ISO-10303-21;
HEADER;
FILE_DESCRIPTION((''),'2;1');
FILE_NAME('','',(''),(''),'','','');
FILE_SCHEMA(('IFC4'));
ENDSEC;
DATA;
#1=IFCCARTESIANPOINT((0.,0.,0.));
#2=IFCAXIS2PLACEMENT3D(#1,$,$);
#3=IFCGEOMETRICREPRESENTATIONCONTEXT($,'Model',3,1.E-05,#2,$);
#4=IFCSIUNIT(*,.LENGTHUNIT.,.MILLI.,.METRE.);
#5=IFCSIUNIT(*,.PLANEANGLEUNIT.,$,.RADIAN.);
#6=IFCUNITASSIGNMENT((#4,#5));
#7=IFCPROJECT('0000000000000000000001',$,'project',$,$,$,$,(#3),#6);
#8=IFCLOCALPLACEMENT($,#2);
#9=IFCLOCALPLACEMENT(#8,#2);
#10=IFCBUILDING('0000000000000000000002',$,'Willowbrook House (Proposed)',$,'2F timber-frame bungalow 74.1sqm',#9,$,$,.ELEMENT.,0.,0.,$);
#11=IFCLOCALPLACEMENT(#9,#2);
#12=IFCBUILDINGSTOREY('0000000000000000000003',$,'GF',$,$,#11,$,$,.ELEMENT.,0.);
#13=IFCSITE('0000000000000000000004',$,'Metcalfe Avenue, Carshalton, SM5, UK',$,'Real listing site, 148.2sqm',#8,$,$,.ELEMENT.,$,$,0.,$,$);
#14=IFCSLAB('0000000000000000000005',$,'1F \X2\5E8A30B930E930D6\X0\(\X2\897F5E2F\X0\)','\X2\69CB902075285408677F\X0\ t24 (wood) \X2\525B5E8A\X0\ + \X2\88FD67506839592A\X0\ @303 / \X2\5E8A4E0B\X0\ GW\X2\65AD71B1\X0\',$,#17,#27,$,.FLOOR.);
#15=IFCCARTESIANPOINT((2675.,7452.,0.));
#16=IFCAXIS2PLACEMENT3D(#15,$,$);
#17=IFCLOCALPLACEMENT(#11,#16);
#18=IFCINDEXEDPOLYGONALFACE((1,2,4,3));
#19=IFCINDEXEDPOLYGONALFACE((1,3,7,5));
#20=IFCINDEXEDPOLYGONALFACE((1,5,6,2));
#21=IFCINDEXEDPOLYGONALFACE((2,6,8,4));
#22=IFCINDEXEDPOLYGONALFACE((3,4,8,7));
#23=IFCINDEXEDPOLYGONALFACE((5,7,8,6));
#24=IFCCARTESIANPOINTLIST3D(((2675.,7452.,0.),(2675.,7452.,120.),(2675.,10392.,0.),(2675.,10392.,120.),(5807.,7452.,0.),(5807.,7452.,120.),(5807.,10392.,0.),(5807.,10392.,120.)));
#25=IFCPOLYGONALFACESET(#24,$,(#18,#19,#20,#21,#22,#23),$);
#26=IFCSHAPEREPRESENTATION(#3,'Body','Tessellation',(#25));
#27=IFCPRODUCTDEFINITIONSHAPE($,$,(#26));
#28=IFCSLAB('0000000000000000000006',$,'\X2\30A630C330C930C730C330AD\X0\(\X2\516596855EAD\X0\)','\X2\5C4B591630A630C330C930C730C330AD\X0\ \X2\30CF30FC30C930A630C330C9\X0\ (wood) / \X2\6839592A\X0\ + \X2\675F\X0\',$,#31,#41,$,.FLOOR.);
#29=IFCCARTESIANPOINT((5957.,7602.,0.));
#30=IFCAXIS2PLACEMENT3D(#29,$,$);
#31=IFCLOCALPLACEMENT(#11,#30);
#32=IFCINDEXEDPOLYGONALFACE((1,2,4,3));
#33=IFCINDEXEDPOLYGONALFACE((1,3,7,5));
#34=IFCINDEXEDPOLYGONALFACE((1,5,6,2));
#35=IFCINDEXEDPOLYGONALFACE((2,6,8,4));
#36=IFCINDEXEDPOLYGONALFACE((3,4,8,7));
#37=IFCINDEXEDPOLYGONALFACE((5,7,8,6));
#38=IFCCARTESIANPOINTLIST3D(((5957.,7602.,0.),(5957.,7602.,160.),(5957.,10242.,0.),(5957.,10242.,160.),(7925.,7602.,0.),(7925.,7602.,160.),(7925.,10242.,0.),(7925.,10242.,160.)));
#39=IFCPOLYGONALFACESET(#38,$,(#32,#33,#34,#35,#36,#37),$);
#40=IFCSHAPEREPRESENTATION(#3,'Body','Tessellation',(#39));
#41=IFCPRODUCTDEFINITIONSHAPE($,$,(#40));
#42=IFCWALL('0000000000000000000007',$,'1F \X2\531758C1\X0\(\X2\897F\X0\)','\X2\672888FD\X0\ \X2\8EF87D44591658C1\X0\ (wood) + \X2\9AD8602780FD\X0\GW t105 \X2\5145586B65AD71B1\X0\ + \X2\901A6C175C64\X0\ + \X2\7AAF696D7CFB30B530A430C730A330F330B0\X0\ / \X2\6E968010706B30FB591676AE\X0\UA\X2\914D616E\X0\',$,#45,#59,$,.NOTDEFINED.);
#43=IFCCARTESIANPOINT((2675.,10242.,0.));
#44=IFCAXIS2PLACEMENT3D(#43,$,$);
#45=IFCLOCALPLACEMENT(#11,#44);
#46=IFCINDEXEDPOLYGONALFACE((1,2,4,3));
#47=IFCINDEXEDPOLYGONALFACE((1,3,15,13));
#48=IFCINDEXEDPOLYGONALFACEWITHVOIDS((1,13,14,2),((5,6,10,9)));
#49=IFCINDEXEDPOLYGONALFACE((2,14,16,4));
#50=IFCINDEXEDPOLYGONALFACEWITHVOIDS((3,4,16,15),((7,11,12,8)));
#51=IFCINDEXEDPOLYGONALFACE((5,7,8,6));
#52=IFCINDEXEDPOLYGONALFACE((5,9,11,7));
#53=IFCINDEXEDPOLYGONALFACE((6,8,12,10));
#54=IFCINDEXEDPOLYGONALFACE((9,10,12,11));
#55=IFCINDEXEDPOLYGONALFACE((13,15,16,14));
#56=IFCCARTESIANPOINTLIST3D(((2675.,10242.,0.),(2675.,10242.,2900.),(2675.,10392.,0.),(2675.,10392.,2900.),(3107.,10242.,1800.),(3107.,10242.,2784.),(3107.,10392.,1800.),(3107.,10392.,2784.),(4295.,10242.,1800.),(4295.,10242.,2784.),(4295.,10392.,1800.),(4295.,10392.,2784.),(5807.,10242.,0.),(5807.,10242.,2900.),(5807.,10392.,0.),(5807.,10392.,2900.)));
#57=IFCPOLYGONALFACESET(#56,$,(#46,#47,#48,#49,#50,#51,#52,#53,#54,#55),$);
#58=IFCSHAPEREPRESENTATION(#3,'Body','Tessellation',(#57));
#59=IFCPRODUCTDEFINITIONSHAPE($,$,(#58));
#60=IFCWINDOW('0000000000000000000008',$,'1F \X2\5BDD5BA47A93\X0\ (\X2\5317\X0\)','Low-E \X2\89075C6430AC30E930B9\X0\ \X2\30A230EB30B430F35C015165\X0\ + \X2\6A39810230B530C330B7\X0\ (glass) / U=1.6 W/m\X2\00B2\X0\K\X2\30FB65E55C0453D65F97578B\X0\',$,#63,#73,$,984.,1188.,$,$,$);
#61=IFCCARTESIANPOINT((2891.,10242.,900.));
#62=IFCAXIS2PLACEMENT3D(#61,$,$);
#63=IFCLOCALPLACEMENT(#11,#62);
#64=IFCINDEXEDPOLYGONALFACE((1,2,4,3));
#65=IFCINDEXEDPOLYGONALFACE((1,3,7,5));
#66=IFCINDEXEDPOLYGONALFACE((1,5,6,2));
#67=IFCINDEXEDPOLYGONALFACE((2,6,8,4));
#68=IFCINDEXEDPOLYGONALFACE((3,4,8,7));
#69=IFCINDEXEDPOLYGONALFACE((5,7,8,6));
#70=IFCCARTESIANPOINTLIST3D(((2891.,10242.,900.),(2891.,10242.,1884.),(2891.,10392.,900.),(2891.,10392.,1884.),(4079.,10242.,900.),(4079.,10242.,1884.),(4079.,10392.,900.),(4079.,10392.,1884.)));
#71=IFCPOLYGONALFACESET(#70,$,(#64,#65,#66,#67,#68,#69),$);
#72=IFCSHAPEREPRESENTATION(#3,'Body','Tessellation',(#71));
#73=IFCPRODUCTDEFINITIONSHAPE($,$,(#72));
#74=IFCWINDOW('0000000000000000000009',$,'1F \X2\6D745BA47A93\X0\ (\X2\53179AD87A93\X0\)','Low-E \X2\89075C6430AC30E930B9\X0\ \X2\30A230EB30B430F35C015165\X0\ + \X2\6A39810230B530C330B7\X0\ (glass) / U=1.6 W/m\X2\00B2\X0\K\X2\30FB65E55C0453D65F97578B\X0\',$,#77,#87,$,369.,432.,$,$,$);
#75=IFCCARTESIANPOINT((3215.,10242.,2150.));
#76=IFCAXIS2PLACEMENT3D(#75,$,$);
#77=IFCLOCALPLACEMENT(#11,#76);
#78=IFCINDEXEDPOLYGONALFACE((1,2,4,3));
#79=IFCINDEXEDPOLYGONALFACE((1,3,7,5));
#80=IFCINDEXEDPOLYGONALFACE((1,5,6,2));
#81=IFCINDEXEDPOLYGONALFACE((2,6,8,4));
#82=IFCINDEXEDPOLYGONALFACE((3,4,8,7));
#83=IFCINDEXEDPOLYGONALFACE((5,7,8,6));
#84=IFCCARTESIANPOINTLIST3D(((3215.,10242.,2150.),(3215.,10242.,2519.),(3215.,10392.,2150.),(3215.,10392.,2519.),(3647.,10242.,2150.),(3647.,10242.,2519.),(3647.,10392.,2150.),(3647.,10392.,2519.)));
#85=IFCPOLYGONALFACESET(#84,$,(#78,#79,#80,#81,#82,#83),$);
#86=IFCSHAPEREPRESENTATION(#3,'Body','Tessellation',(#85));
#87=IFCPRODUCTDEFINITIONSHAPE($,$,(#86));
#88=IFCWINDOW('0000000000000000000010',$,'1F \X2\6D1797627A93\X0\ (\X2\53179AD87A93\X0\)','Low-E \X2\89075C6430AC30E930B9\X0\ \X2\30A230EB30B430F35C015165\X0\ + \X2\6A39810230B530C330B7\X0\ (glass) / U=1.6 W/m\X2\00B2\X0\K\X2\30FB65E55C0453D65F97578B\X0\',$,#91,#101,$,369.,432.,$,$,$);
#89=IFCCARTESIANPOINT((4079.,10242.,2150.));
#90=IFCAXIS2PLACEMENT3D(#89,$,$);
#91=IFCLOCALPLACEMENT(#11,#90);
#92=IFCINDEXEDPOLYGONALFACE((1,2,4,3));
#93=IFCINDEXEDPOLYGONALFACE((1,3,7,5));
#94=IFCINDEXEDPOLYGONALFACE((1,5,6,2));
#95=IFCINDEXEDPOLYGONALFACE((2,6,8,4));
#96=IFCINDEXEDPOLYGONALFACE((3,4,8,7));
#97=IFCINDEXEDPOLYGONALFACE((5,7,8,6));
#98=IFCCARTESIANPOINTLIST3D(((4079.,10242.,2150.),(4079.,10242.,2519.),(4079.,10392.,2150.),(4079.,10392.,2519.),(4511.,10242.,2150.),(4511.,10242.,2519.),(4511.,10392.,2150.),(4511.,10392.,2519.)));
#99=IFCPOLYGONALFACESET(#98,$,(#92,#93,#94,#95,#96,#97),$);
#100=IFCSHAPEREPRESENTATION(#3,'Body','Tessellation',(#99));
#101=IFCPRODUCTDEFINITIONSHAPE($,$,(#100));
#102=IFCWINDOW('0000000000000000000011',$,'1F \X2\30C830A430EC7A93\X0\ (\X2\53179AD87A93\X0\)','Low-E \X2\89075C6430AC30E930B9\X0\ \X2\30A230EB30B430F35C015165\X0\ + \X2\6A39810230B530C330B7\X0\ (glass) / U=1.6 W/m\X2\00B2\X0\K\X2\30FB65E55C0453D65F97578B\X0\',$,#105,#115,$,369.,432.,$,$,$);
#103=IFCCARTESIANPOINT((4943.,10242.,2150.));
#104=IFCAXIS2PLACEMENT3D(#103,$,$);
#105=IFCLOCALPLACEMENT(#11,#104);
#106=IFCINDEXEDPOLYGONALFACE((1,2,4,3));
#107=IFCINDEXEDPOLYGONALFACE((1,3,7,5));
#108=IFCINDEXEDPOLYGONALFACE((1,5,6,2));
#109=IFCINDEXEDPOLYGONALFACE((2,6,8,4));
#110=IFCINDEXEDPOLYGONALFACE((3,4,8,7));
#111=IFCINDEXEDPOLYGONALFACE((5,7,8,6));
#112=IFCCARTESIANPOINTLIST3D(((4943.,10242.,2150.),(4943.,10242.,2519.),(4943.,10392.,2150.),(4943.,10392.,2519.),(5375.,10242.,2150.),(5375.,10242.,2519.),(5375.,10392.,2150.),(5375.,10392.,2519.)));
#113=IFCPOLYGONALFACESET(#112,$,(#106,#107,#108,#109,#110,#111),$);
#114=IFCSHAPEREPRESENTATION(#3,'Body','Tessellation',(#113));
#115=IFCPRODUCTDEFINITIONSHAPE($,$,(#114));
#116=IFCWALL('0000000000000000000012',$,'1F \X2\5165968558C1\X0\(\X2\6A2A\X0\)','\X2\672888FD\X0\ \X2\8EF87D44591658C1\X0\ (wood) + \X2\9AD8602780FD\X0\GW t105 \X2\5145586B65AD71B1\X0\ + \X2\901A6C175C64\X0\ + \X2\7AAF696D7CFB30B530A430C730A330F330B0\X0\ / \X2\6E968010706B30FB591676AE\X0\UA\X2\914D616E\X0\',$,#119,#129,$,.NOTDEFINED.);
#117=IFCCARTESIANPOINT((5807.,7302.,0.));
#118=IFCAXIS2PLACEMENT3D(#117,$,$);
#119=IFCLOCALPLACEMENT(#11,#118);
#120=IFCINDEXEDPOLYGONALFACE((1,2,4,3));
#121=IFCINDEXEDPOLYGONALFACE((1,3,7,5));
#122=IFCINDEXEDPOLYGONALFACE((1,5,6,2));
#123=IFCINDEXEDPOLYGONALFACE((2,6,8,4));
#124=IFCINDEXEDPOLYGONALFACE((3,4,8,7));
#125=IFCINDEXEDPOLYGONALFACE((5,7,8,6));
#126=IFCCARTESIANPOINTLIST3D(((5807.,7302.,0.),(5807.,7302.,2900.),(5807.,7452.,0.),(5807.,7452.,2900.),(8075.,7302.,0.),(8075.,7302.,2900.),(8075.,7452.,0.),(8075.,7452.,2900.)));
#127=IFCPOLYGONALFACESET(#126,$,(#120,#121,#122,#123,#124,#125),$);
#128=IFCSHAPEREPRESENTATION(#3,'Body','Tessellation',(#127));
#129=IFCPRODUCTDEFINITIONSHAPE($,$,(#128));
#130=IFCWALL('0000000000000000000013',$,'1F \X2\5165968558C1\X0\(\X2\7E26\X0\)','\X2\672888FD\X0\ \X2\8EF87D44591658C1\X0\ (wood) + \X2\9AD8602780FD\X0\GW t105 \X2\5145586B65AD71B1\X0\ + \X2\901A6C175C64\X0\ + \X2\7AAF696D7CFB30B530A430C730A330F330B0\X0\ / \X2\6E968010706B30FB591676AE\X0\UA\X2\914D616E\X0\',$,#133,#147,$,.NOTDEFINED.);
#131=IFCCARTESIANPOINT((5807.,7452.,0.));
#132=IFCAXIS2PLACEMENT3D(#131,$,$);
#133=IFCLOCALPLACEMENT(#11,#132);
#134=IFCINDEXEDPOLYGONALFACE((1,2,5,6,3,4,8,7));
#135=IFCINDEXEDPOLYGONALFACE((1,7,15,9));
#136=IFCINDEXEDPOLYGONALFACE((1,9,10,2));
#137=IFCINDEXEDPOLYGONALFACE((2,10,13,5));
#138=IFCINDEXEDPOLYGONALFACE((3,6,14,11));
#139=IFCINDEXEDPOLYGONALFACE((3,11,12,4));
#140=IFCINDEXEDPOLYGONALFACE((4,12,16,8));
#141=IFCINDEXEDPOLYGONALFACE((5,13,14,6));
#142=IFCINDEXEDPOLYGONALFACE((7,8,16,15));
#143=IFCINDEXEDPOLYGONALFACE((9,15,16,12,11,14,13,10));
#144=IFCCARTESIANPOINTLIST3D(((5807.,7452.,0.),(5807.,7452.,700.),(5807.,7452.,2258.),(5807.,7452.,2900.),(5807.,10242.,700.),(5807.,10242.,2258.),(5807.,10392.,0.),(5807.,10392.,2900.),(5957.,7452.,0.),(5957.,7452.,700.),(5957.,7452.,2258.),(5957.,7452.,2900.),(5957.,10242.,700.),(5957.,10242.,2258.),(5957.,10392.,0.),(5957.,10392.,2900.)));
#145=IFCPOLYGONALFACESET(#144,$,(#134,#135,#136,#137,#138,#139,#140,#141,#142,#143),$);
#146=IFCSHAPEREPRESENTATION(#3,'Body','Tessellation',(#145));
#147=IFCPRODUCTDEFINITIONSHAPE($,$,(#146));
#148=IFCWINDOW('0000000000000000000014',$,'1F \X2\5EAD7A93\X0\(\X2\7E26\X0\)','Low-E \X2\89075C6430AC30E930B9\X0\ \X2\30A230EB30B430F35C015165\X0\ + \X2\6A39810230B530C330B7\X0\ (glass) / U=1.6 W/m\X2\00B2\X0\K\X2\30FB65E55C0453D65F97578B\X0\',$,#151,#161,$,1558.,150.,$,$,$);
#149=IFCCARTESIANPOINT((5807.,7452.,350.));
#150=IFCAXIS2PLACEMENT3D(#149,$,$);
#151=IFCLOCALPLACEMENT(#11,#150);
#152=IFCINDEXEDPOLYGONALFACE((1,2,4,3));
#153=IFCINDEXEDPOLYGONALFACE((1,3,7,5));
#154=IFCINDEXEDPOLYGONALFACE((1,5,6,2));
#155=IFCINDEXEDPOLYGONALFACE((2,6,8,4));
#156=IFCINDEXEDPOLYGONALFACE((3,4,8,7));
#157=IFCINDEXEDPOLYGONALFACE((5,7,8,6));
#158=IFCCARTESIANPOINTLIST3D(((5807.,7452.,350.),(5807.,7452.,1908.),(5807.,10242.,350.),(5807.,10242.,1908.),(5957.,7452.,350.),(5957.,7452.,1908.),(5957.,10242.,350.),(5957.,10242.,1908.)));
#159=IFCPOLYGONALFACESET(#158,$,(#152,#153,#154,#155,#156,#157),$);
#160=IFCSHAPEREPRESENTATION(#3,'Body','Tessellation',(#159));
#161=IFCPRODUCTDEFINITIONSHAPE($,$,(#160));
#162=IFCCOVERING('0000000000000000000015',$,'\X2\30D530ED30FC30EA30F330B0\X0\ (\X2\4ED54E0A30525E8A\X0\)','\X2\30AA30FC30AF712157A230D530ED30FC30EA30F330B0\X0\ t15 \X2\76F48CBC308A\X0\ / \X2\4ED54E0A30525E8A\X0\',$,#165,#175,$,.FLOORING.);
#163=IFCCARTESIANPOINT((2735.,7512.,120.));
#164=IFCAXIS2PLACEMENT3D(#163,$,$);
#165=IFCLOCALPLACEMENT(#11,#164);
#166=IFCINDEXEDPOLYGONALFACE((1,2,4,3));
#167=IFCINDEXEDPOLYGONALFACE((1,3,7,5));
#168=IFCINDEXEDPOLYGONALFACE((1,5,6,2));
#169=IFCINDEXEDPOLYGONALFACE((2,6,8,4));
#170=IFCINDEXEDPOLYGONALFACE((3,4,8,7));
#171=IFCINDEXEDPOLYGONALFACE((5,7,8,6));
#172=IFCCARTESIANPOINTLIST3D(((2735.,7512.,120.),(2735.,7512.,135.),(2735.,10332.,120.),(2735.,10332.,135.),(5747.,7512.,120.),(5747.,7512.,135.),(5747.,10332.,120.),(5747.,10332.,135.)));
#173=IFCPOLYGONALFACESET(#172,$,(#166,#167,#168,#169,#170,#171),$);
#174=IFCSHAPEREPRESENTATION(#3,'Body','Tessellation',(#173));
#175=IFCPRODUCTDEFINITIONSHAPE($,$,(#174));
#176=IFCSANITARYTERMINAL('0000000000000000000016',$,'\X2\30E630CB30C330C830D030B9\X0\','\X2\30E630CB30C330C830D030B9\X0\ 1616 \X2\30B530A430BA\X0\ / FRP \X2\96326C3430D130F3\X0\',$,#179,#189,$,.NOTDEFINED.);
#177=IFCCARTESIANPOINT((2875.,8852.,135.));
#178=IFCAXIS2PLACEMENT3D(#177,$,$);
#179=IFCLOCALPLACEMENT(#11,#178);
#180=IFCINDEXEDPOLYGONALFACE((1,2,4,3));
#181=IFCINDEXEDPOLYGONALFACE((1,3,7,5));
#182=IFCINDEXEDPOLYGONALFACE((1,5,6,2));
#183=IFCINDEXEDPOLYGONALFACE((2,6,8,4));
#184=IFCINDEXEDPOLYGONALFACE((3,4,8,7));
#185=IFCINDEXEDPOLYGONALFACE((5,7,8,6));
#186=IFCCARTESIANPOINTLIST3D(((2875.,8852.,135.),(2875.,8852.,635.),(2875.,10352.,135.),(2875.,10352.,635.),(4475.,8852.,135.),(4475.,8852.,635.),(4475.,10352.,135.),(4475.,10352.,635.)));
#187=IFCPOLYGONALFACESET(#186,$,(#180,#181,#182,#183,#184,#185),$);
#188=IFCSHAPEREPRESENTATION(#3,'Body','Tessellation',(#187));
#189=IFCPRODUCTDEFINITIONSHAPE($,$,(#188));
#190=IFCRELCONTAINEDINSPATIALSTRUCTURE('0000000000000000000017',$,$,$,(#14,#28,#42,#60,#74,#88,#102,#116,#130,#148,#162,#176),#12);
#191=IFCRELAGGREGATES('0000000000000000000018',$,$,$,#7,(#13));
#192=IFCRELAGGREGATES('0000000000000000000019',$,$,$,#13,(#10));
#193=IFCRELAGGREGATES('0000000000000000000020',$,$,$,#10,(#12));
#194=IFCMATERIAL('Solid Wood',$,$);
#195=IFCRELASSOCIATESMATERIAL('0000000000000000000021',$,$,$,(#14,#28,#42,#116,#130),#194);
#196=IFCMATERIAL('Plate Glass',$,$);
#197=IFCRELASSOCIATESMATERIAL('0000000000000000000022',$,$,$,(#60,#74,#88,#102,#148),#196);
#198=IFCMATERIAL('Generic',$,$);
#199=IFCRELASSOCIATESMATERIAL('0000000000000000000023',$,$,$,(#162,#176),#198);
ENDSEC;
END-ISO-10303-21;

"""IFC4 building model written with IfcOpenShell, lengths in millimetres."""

from ifc_helpers import new_model, si_unit, frame, frame_2d, origin, place, context, project, spatial, rectangle, extrude, material, element, fill, save


model = new_model("IFC4")

# Units and contexts
model_context = context("Model", 3, precision=1e-05, world=origin())
ifc_project = project(units=[si_unit("LENGTHUNIT", "METRE", prefix="MILLI"), si_unit("PLANEANGLEUNIT", "RADIAN")], contexts=[model_context])

# Site, building, storey
site_placement = place(None, origin())
site = spatial("IfcSite", under=ifc_project, at=site_placement, Name="Metcalfe Avenue, Carshalton, SM5, UK", ObjectType="Real listing site, 148.2sqm", CompositionType="ELEMENT", RefElevation=0.0)
building_placement = place(site_placement, origin())
building = spatial("IfcBuilding", under=site, at=building_placement, Name="Willowbrook House (Proposed)", ObjectType="2F timber-frame bungalow 74.1sqm", CompositionType="ELEMENT", ElevationOfRefHeight=0.0, ElevationOfTerrain=0.0)
storey_placement = place(building_placement, origin())
storey = spatial("IfcBuildingStorey", under=building, at=storey_placement, Name="GF", CompositionType="ELEMENT", Elevation=0.0)

# Slabs
ifc_material_1 = material(Name="Solid Wood")
slab_1_placement = place(storey_placement, frame((2675.0, 7452.0, 0.0)))
element("IfcSlab", 1, at=slab_1_placement, inside=storey, material=ifc_material_1, Name="1F 床スラブ(西帯)", Description="構造用合板 t24 (wood) 剛床 + 製材根太 @303 / 床下 GW断熱", PredefinedType="FLOOR", context=model_context, shape_type="SweptSolid", body=[
    extrude(rectangle(XDim=3132.0, YDim=2940.0, at=frame_2d((1566.0, 1470.0))), frame((2675.0, 7452.0, 0.0)), (0.0, 0.0, 1.0), 120.0),
])
slab_2_placement = place(storey_placement, frame((5957.0, 7602.0, 0.0)))
element("IfcSlab", 2, at=slab_2_placement, inside=storey, material=ifc_material_1, Name="ウッドデッキ(入隅庭)", Description="屋外ウッドデッキ ハードウッド (wood) / 根太 + 束", PredefinedType="FLOOR", context=model_context, shape_type="SweptSolid", body=[
    extrude(rectangle(XDim=1968.0, YDim=2640.0, at=frame_2d((984.0, 1320.0))), frame((5957.0, 7602.0, 0.0)), (0.0, 0.0, 1.0), 160.0),
])

# Wall, openings, windows
wall_1_placement = place(storey_placement, frame((2675.0, 10242.0, 0.0)))
wall_1 = element("IfcWall", 3, at=wall_1_placement, inside=storey, material=ifc_material_1, Name="1F 北壁(西)", Description="木製 軸組外壁 (wood) + 高性能GW t105 充填断熱 + 通気層 + 窯業系サイディング / 準耐火・外皮UA配慮", PredefinedType="NOTDEFINED", context=model_context, shape_type="SweptSolid", body=[
    extrude(rectangle(XDim=3132.0, YDim=150.0, at=frame_2d((1566.0, 75.0))), frame((2675.0, 10242.0, 0.0)), (0.0, 0.0, 1.0), 2900.0),
])
opening_1_placement = place(storey_placement, frame((2891.0, 10242.0, 900.0)))
opening_1 = element("IfcOpeningElement", 4, at=opening_1_placement, cuts=wall_1, PredefinedType="NOTDEFINED", context=model_context, shape_type="SweptSolid", body=[
    extrude(rectangle(XDim=1188.0, YDim=150.0, at=frame_2d((594.0, 75.0))), frame((2891.0, 10242.0, 900.0)), (0.0, 0.0, 1.0), 984.0),
])
opening_2_placement = place(storey_placement, frame((3215.0, 10242.0, 2150.0)))
opening_2 = element("IfcOpeningElement", 5, at=opening_2_placement, cuts=wall_1, PredefinedType="NOTDEFINED", context=model_context, shape_type="SweptSolid", body=[
    extrude(rectangle(XDim=432.0, YDim=150.0, at=frame_2d((216.0, 75.0))), frame((3215.0, 10242.0, 2150.0)), (0.0, 0.0, 1.0), 369.0),
])
opening_3_placement = place(storey_placement, frame((4079.0, 10242.0, 2150.0)))
opening_3 = element("IfcOpeningElement", 6, at=opening_3_placement, cuts=wall_1, PredefinedType="NOTDEFINED", context=model_context, shape_type="SweptSolid", body=[
    extrude(rectangle(XDim=432.0, YDim=150.0, at=frame_2d((216.0, 75.0))), frame((4079.0, 10242.0, 2150.0)), (0.0, 0.0, 1.0), 369.0),
])
opening_4_placement = place(storey_placement, frame((4943.0, 10242.0, 2150.0)))
opening_4 = element("IfcOpeningElement", 7, at=opening_4_placement, cuts=wall_1, PredefinedType="NOTDEFINED", context=model_context, shape_type="SweptSolid", body=[
    extrude(rectangle(XDim=432.0, YDim=150.0, at=frame_2d((216.0, 75.0))), frame((4943.0, 10242.0, 2150.0)), (0.0, 0.0, 1.0), 369.0),
])
ifc_material_2 = material(Name="Plate Glass")
window_1_placement = place(storey_placement, frame((2891.0, 10242.0, 900.0)))
window_1 = element("IfcWindow", 8, at=window_1_placement, inside=storey, material=ifc_material_2, Name="1F 寝室窓 (北)", Description="Low-E 複層ガラス アルゴン封入 + 樹脂サッシ (glass) / U=1.6 W/m²K・日射取得型", OverallHeight=984.0, OverallWidth=1188.0, context=model_context, shape_type="SweptSolid", body=[
    extrude(rectangle(XDim=1188.0, YDim=150.0, at=frame_2d((594.0, 75.0))), frame((2891.0, 10242.0, 900.0)), (0.0, 0.0, 1.0), 984.0),
])
fill(opening_1, window_1)
window_2_placement = place(storey_placement, frame((3215.0, 10242.0, 2150.0)))
window_2 = element("IfcWindow", 9, at=window_2_placement, inside=storey, material=ifc_material_2, Name="1F 浴室窓 (北高窓)", Description="Low-E 複層ガラス アルゴン封入 + 樹脂サッシ (glass) / U=1.6 W/m²K・日射取得型", OverallHeight=369.0, OverallWidth=432.0, context=model_context, shape_type="SweptSolid", body=[
    extrude(rectangle(XDim=432.0, YDim=150.0, at=frame_2d((216.0, 75.0))), frame((3215.0, 10242.0, 2150.0)), (0.0, 0.0, 1.0), 369.0),
])
fill(opening_2, window_2)
window_3_placement = place(storey_placement, frame((4079.0, 10242.0, 2150.0)))
window_3 = element("IfcWindow", 10, at=window_3_placement, inside=storey, material=ifc_material_2, Name="1F 洗面窓 (北高窓)", Description="Low-E 複層ガラス アルゴン封入 + 樹脂サッシ (glass) / U=1.6 W/m²K・日射取得型", OverallHeight=369.0, OverallWidth=432.0, context=model_context, shape_type="SweptSolid", body=[
    extrude(rectangle(XDim=432.0, YDim=150.0, at=frame_2d((216.0, 75.0))), frame((4079.0, 10242.0, 2150.0)), (0.0, 0.0, 1.0), 369.0),
])
fill(opening_3, window_3)
window_4_placement = place(storey_placement, frame((4943.0, 10242.0, 2150.0)))
window_4 = element("IfcWindow", 11, at=window_4_placement, inside=storey, material=ifc_material_2, Name="1F トイレ窓 (北高窓)", Description="Low-E 複層ガラス アルゴン封入 + 樹脂サッシ (glass) / U=1.6 W/m²K・日射取得型", OverallHeight=369.0, OverallWidth=432.0, context=model_context, shape_type="SweptSolid", body=[
    extrude(rectangle(XDim=432.0, YDim=150.0, at=frame_2d((216.0, 75.0))), frame((4943.0, 10242.0, 2150.0)), (0.0, 0.0, 1.0), 369.0),
])
fill(opening_4, window_4)

# Wall
wall_2_placement = place(storey_placement, frame((5807.0, 7302.0, 0.0)))
element("IfcWall", 12, at=wall_2_placement, inside=storey, material=ifc_material_1, Name="1F 入隅壁(横)", Description="木製 軸組外壁 (wood) + 高性能GW t105 充填断熱 + 通気層 + 窯業系サイディング / 準耐火・外皮UA配慮", PredefinedType="NOTDEFINED", context=model_context, shape_type="SweptSolid", body=[
    extrude(rectangle(XDim=2268.0, YDim=150.0, at=frame_2d((1134.0, 75.0))), frame((5807.0, 7302.0, 0.0)), (0.0, 0.0, 1.0), 2900.0),
])

# Wall, opening, window
wall_3_placement = place(storey_placement, frame((5807.0, 7452.0, 0.0)))
wall_3 = element("IfcWall", 13, at=wall_3_placement, inside=storey, material=ifc_material_1, Name="1F 入隅壁(縦)", Description="木製 軸組外壁 (wood) + 高性能GW t105 充填断熱 + 通気層 + 窯業系サイディング / 準耐火・外皮UA配慮", PredefinedType="NOTDEFINED", context=model_context, shape_type="SweptSolid", body=[
    extrude(rectangle(XDim=150.0, YDim=2940.0, at=frame_2d((75.0, 1470.0))), frame((5807.0, 7452.0, 0.0)), (0.0, 0.0, 1.0), 2900.0),
])
opening_5_placement = place(storey_placement, frame((5807.0, 7452.0, 350.0)))
opening_5 = element("IfcOpeningElement", 14, at=opening_5_placement, cuts=wall_3, PredefinedType="NOTDEFINED", context=model_context, shape_type="SweptSolid", body=[
    extrude(rectangle(XDim=150.0, YDim=2790.0, at=frame_2d((75.0, 1395.0))), frame((5807.0, 7452.0, 350.0)), (0.0, 0.0, 1.0), 1558.0),
])
window_5_placement = place(storey_placement, frame((5807.0, 7452.0, 350.0)))
window_5 = element("IfcWindow", 15, at=window_5_placement, inside=storey, material=ifc_material_2, Name="1F 庭窓(縦)", Description="Low-E 複層ガラス アルゴン封入 + 樹脂サッシ (glass) / U=1.6 W/m²K・日射取得型", OverallHeight=1558.0, OverallWidth=150.0, context=model_context, shape_type="SweptSolid", body=[
    extrude(rectangle(XDim=150.0, YDim=2790.0, at=frame_2d((75.0, 1395.0))), frame((5807.0, 7452.0, 350.0)), (0.0, 0.0, 1.0), 1558.0),
])
fill(opening_5, window_5)

# Covering
ifc_material_3 = material(Name="Generic")
covering_placement = place(storey_placement, frame((2735.0, 7512.0, 120.0)))
element("IfcCovering", 16, at=covering_placement, inside=storey, material=ifc_material_3, Name="フローリング (仕上げ床)", Description="オーク無垢フローリング t15 直貼り / 仕上げ床", PredefinedType="FLOORING", context=model_context, shape_type="SweptSolid", body=[
    extrude(rectangle(XDim=3012.0, YDim=2820.0, at=frame_2d((1506.0, 1410.0))), frame((2735.0, 7512.0, 120.0)), (0.0, 0.0, 1.0), 15.0),
])

# Sanitary terminal
sanitary_terminal_1_placement = place(storey_placement, frame((2875.0, 8852.0, 135.0)))
element("IfcSanitaryTerminal", 17, at=sanitary_terminal_1_placement, inside=storey, material=ifc_material_3, Name="ユニットバス", Description="ユニットバス 1616 サイズ / FRP 防水パン", PredefinedType="NOTDEFINED", context=model_context, shape_type="SweptSolid", body=[
    extrude(rectangle(XDim=1600.0, YDim=1500.0, at=frame_2d((800.0, 750.0))), frame((2875.0, 8852.0, 135.0)), (0.0, 0.0, 1.0), 500.0),
])

save(model, "model.ifc")
